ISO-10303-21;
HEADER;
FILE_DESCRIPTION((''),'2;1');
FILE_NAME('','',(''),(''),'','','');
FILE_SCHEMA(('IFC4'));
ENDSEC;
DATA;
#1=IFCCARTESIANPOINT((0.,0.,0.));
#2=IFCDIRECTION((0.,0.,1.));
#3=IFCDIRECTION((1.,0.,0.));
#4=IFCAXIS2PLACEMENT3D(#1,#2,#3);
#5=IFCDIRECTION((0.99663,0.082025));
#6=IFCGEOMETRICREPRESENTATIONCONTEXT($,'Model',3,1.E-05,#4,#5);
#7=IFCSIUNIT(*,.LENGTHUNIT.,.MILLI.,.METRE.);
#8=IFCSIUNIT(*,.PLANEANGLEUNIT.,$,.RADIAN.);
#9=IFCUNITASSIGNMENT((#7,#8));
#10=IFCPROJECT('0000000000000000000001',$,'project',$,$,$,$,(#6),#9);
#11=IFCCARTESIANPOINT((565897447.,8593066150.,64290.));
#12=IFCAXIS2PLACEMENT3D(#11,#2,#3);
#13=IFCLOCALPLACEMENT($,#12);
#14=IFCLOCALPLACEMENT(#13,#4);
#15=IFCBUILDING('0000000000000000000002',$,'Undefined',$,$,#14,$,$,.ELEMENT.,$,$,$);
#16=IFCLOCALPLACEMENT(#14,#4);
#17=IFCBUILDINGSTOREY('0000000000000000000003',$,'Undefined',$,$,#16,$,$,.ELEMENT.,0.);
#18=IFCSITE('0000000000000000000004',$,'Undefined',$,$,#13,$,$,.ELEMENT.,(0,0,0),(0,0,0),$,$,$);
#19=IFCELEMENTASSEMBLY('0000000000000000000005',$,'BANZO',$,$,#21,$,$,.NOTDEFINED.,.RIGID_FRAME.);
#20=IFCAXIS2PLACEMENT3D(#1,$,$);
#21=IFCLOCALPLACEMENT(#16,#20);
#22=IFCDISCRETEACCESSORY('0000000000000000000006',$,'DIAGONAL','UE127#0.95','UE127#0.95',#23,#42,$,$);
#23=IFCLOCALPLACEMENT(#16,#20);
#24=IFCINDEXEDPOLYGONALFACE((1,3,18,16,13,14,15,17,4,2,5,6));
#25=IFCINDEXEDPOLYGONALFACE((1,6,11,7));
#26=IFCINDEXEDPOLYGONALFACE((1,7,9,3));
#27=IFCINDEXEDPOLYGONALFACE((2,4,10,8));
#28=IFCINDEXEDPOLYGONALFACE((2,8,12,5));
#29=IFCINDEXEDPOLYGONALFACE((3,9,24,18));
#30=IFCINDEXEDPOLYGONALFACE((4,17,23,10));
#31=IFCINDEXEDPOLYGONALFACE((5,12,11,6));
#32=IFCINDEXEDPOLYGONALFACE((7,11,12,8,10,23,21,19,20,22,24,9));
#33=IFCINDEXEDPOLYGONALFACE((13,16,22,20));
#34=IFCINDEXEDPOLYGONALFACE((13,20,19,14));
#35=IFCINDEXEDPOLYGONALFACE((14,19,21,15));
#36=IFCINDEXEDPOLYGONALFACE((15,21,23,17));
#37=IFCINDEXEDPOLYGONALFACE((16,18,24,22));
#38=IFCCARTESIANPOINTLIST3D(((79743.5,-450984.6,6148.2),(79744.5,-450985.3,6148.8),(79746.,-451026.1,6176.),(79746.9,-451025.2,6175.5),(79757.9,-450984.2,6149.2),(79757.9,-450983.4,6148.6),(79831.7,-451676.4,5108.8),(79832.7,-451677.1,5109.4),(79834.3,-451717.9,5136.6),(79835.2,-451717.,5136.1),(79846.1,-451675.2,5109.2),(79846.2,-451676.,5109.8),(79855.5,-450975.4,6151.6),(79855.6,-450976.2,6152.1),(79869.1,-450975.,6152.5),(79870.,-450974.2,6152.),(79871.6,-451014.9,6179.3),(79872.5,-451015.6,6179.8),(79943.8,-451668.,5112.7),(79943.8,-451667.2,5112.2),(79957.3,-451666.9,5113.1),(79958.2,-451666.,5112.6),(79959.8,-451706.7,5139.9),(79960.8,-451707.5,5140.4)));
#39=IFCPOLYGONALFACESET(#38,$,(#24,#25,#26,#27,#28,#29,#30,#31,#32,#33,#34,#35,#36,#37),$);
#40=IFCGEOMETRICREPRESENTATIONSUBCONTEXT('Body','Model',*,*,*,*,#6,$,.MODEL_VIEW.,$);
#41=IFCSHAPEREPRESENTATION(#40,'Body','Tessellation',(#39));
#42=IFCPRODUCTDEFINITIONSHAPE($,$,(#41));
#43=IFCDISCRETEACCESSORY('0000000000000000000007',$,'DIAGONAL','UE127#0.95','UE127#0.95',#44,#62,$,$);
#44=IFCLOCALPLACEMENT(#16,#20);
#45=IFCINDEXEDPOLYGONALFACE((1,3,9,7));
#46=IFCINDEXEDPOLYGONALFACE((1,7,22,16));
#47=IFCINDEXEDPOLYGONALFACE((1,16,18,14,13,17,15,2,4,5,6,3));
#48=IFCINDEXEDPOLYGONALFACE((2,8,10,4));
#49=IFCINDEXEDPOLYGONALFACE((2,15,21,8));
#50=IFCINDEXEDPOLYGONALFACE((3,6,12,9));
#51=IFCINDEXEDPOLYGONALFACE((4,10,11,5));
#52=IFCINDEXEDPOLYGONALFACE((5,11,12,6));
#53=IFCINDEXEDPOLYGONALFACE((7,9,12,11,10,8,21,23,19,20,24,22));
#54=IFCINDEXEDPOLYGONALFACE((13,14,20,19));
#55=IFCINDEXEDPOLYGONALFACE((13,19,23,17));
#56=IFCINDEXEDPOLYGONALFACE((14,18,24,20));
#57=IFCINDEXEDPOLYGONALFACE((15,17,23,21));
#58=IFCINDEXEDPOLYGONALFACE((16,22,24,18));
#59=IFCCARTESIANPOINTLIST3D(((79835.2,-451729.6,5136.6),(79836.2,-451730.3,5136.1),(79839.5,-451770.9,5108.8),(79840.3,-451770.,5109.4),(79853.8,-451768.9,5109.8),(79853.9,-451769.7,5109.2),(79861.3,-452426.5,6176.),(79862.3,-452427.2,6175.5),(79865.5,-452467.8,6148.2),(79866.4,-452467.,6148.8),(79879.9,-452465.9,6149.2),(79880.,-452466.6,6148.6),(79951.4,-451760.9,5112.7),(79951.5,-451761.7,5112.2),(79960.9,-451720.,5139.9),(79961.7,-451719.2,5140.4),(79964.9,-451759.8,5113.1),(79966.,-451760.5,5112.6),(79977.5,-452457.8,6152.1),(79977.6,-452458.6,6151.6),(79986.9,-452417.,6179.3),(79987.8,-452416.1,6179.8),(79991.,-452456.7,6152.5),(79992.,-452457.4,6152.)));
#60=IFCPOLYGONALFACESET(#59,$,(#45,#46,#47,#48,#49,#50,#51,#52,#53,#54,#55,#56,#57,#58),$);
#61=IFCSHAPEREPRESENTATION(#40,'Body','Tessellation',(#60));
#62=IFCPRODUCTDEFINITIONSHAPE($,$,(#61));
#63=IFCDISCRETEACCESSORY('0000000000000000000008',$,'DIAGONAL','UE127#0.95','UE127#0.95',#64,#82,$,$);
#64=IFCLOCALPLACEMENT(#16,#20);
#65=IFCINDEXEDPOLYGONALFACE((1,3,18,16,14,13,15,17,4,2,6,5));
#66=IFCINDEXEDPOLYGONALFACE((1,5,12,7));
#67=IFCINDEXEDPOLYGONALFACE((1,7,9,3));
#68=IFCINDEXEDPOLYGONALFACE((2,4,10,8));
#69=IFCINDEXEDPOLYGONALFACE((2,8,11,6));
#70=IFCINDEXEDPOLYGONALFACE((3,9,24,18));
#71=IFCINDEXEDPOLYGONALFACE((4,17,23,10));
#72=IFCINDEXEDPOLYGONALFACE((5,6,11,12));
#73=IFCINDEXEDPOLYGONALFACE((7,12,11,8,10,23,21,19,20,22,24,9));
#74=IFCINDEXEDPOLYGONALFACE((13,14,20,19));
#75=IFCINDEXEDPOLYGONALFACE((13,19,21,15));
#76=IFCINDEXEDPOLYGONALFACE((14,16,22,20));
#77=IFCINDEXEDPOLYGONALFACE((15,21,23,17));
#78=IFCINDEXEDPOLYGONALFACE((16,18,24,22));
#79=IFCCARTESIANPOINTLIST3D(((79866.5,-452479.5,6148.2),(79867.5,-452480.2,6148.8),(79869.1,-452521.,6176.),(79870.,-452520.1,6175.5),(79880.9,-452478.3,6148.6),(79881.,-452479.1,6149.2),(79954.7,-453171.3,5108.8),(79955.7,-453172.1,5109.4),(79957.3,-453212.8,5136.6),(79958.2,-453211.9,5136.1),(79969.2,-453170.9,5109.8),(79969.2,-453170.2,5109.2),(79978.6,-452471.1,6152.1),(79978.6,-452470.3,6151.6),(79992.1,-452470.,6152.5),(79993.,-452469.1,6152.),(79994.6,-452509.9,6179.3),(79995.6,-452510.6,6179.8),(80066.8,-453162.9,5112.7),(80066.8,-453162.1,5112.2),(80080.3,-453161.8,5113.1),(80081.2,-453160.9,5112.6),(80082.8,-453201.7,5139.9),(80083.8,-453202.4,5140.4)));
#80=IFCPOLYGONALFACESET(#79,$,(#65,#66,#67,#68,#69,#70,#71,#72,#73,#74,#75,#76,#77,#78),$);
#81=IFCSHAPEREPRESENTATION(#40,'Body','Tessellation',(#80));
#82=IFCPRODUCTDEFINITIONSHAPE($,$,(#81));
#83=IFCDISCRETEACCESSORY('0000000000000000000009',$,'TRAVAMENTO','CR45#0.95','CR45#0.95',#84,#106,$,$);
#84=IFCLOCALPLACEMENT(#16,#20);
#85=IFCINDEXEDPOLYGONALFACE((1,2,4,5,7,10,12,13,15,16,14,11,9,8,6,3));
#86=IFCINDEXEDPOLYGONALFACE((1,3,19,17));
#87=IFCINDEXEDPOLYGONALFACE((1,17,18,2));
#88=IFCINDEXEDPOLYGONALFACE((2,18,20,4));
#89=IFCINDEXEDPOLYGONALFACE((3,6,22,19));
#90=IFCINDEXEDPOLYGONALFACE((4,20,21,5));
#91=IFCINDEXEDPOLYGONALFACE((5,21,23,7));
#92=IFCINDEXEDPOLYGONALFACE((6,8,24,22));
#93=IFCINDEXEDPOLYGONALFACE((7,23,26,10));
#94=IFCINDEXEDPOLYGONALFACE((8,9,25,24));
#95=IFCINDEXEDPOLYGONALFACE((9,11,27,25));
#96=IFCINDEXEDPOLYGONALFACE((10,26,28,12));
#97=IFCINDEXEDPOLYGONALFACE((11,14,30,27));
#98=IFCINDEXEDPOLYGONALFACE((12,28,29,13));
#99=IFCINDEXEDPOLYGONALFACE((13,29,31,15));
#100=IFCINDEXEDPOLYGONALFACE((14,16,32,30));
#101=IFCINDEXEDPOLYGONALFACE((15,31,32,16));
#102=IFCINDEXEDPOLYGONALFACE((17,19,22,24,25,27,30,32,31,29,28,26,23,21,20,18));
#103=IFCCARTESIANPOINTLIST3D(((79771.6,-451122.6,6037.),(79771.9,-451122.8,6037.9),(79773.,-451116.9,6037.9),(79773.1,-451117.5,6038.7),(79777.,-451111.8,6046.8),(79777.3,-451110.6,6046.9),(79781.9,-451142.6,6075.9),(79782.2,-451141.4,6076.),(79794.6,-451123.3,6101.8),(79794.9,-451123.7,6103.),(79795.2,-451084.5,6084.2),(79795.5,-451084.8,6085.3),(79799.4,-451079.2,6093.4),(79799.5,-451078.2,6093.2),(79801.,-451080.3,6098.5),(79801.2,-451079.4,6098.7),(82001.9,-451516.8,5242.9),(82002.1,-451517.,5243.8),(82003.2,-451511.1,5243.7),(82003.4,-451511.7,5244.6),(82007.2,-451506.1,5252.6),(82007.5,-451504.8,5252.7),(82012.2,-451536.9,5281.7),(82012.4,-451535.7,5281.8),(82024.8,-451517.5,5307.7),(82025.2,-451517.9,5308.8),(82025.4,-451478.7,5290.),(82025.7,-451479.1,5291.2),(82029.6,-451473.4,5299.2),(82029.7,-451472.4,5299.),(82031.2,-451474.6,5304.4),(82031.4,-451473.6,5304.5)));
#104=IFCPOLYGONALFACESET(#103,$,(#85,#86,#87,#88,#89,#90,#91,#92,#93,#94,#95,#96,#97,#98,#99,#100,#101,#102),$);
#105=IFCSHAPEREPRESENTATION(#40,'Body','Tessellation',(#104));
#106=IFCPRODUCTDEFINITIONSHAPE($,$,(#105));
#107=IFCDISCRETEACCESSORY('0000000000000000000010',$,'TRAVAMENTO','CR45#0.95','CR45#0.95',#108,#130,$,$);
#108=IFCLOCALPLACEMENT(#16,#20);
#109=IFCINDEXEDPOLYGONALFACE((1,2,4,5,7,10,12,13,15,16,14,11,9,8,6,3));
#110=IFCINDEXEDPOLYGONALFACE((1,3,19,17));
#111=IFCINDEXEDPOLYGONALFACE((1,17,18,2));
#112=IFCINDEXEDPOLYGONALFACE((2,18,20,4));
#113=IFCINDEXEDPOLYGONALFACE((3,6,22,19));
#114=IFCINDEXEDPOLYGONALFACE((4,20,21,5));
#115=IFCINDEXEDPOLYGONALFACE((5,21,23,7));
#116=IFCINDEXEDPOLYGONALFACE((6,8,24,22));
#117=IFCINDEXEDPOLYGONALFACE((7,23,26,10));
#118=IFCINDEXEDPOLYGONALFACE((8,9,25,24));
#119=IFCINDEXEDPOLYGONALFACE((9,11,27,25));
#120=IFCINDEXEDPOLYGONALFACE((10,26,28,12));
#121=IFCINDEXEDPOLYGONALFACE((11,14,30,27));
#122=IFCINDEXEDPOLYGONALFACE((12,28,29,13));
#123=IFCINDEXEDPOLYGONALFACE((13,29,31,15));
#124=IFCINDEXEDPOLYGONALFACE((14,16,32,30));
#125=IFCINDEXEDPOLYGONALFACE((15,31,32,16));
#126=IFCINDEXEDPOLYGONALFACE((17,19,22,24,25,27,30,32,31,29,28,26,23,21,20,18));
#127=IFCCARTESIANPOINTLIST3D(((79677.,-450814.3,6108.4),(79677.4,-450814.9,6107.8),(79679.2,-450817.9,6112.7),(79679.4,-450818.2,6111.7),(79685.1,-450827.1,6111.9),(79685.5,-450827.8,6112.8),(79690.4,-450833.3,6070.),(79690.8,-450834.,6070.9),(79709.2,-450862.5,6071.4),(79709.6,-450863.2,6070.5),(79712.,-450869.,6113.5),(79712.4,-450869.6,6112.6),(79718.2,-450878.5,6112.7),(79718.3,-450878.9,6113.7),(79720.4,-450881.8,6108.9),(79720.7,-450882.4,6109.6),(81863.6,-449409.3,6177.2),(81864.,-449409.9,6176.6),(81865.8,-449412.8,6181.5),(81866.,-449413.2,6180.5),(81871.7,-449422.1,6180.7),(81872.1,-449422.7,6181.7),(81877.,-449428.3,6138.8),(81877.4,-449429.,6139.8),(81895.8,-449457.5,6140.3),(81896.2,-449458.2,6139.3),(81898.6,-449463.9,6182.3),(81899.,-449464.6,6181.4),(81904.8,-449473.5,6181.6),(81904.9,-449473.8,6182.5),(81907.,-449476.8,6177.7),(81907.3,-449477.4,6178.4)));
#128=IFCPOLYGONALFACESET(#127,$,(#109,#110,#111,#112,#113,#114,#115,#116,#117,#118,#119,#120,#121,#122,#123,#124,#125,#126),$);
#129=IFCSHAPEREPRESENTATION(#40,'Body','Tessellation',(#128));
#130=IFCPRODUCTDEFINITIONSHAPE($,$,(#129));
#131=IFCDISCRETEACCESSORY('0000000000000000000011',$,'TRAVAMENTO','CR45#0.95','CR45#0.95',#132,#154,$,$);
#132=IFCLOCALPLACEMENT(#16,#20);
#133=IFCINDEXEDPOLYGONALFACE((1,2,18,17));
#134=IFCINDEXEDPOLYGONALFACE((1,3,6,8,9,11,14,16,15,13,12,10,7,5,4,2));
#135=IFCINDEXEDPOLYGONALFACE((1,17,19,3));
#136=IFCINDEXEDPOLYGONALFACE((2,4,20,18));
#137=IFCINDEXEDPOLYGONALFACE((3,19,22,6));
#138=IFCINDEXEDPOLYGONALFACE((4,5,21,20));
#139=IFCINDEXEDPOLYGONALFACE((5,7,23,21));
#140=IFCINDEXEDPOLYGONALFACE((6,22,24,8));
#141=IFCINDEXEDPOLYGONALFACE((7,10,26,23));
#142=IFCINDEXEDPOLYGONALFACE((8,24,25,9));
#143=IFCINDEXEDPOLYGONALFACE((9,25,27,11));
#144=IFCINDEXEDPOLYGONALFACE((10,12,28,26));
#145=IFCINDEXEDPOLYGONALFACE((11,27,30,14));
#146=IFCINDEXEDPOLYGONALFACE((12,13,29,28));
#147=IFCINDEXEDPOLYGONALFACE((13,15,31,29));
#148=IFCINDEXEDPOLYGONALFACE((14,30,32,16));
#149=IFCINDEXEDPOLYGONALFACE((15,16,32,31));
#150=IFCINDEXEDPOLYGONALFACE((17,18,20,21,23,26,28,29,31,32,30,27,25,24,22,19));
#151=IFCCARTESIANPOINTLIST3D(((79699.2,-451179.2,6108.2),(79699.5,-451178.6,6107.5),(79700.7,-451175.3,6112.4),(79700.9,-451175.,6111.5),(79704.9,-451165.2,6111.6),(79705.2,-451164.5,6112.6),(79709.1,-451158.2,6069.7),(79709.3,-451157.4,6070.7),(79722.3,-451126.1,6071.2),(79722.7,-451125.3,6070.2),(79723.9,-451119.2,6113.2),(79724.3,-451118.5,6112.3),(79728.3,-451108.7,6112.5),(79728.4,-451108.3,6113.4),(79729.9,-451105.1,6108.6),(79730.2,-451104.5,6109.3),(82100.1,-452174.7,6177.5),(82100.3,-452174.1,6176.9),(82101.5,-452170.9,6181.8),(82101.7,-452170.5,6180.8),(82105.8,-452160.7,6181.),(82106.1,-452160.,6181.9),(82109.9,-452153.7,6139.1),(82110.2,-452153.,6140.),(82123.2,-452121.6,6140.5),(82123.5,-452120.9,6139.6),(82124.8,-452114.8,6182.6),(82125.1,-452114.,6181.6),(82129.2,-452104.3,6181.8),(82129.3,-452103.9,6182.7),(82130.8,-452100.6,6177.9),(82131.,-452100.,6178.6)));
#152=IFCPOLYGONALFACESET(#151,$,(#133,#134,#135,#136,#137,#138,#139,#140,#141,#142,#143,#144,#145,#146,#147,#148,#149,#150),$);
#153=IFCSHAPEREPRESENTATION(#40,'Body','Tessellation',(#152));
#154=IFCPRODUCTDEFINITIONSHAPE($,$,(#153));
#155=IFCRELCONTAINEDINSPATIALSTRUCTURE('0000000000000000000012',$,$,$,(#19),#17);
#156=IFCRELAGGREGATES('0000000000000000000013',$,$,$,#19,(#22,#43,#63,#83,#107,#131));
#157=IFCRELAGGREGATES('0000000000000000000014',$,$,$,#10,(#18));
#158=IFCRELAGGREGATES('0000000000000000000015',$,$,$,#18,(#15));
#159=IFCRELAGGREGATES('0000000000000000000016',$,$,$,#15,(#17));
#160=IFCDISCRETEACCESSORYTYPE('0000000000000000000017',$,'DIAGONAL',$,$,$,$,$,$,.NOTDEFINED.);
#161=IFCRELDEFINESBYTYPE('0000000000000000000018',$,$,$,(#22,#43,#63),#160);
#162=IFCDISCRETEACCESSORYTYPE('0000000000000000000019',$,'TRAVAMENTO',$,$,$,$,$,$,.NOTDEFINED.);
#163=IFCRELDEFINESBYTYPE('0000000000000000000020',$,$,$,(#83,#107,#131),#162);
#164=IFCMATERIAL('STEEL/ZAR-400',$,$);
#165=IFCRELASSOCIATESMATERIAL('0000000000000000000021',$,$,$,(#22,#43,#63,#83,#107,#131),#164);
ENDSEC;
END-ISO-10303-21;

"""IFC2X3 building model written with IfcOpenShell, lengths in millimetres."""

from ifc_helpers import new_model, si_unit, direction, frame, frame_2d, origin_with_axes, place, context, subcontext, project, spatial, polyline, c_section, outline, extrude, material, type_object, element, aggregate, save


model = new_model("IFC2X3")

# Units and contexts
model_context = context("Model", 3, precision=1e-05, world=origin_with_axes(), true_north=direction((0.99663, 0.082025)))
body_context = subcontext(model_context, "Body", "Model", "MODEL_VIEW")
ifc_project = project(units=[si_unit("LENGTHUNIT", "METRE", prefix="MILLI"), si_unit("PLANEANGLEUNIT", "RADIAN")], contexts=[model_context])

# Site, building, storey
site_placement = place(None, frame((565897447.0, 8593066150.0, 64290.0), z_axis=(0.0, 0.0, 1.0), x_axis=(1.0, 0.0, 0.0)))
site = spatial("IfcSite", under=ifc_project, at=site_placement, Name="Undefined", CompositionType="ELEMENT", RefLatitude=(0, 0, 0), RefLongitude=(0, 0, 0))
building_placement = place(site_placement, origin_with_axes())
building = spatial("IfcBuilding", under=site, at=building_placement, Name="Undefined", CompositionType="ELEMENT")
storey_placement = place(building_placement, origin_with_axes())
storey = spatial("IfcBuildingStorey", under=building, at=storey_placement, Name="Undefined", CompositionType="ELEMENT", Elevation=0.0)

# Element assembly, discrete accessories
assembly_1_placement = place(storey_placement, origin_with_axes())
assembly_1 = element("IfcElementAssembly", 1, at=assembly_1_placement, inside=storey, Name="BANZO", AssemblyPlace="NOTDEFINED", PredefinedType="RIGID_FRAME")
ifc_material_1 = material(Name="STEEL/ZAR-400")
discrete_accessory_type_1 = type_object("IfcDiscreteAccessoryType", Name="DIAGONAL")
discrete_accessory_1_placement = place(assembly_1_placement, frame((79808.0, -451000.1, 6164.0), z_axis=(-0.996182, -0.081989, -0.029987), x_axis=(0.070485, -0.552697, -0.830396)))
discrete_accessory_1 = element("IfcDiscreteAccessory", 2, at=discrete_accessory_1_placement, type_object=discrete_accessory_type_1, material=ifc_material_1, Name="DIAGONAL", Description="UE127#0.95", ObjectType="UE127#0.95", context=body_context, shape_type="SweptSolid", body=[
    extrude(c_section(Depth=127.0, Width=50.0, WallThickness=0.9, Girth=14.5, at=frame_2d((0.0, 0.0), x_axis=(1.0, 0.0))), frame((1251.7, 0.0, 0.0), z_axis=(-1.0, 0.0, 0.0), x_axis=(0.0, -1.0, 0.0)), (0.0, 0.0, 1.0), 1251.7),
])
discrete_accessory_2_placement = place(assembly_1_placement, frame((79900.6, -451745.0, 5124.6), z_axis=(-0.996182, -0.081989, -0.029987), x_axis=(0.020829, -0.556784, 0.830396)))
discrete_accessory_2 = element("IfcDiscreteAccessory", 3, at=discrete_accessory_2_placement, type_object=discrete_accessory_type_1, material=ifc_material_1, Name="DIAGONAL", Description="UE127#0.95", ObjectType="UE127#0.95", context=body_context, shape_type="SweptSolid", body=[
    extrude(c_section(Depth=127.0, Width=50.0, WallThickness=0.9, Girth=14.5, at=frame_2d((0.0, 0.0), x_axis=(1.0, 0.0))), frame((1251.7, 0.0, 0.0), z_axis=(-1.0, 0.0, 0.0), x_axis=(0.0, -1.0, 0.0)), (0.0, 0.0, 1.0), 1251.7),
])
discrete_accessory_3_placement = place(assembly_1_placement, frame((79931.0, -452495.1, 6164.0), z_axis=(-0.996182, -0.081989, -0.029987), x_axis=(0.070485, -0.552697, -0.830396)))
discrete_accessory_3 = element("IfcDiscreteAccessory", 4, at=discrete_accessory_3_placement, type_object=discrete_accessory_type_1, material=ifc_material_1, Name="DIAGONAL", Description="UE127#0.95", ObjectType="UE127#0.95", context=body_context, shape_type="SweptSolid", body=[
    extrude(c_section(Depth=127.0, Width=50.0, WallThickness=0.9, Girth=14.5, at=frame_2d((0.0, 0.0), x_axis=(1.0, 0.0))), frame((1251.7, 0.0, 0.0), z_axis=(-1.0, 0.0, 0.0), x_axis=(0.0, -1.0, 0.0)), (0.0, 0.0, 1.0), 1251.7),
])
discrete_accessory_type_2 = type_object("IfcDiscreteAccessoryType", Name="TRAVAMENTO")
discrete_accessory_4_placement = place(assembly_1_placement, frame((82017.4, -451509.8, 5283.1), z_axis=(0.05151, -0.82934, 0.556366), x_axis=(-0.929259, 0.164269, 0.330898)))
discrete_accessory_4 = element("IfcDiscreteAccessory", 5, at=discrete_accessory_4_placement, type_object=discrete_accessory_type_2, material=ifc_material_1, Name="TRAVAMENTO", Description="CR45#0.95", ObjectType="CR45#0.95", context=body_context, shape_type="SweptSolid", body=[
    extrude(outline(polyline([(-35.5, -20.5), (-24.9, -20.5), (-17.4, 21.5), (18.1, 21.5), (25.6, -20.5), (36.2, -20.5), (40.1, -16.6), (40.8, -17.3), (36.6, -21.5), (24.8, -21.5), (17.3, 20.5), (-16.6, 20.5), (-24.1, -21.5), (-35.9, -21.5), (-40.1, -17.3), (-39.4, -16.6), (-35.5, -20.5)])), frame((2400.0, 0.0, 0.0), z_axis=(-1.0, 0.0, 0.0), x_axis=(0.0, -1.0, 0.0)), (0.0, 0.0, 1.0), 2400.0),
])
discrete_accessory_5_placement = place(assembly_1_placement, frame((79699.6, -450848.6, 6091.7), z_axis=(0.029886, 0.00246, -0.99955), x_axis=(0.840995, 0.540395, 0.026476)))
discrete_accessory_5 = element("IfcDiscreteAccessory", 6, at=discrete_accessory_5_placement, type_object=discrete_accessory_type_2, material=ifc_material_1, Name="TRAVAMENTO", Description="CR45#0.95", ObjectType="CR45#0.95", context=body_context, shape_type="SweptSolid", body=[
    extrude(outline(polyline([(-35.5, -20.5), (-24.9, -20.5), (-17.4, 21.5), (18.1, 21.5), (25.6, -20.5), (36.2, -20.5), (40.1, -16.6), (40.8, -17.3), (36.6, -21.5), (24.8, -21.5), (17.3, 20.5), (-16.6, 20.5), (-24.1, -21.5), (-35.9, -21.5), (-40.1, -17.3), (-39.4, -16.6), (-35.5, -20.5)])), frame((2600.0, 0.0, 0.0), z_axis=(-1.0, 0.0, 0.0), x_axis=(0.0, -1.0, 0.0)), (0.0, 0.0, 1.0), 2600.0),
])
discrete_accessory_6_placement = place(assembly_1_placement, frame((82116.2, -452137.0, 6160.8), z_axis=(0.029887, 0.002459, -0.99955), x_axis=(-0.923403, 0.382903, -0.026668)))
discrete_accessory_6 = element("IfcDiscreteAccessory", 7, at=discrete_accessory_6_placement, type_object=discrete_accessory_type_2, material=ifc_material_1, Name="TRAVAMENTO", Description="CR45#0.95", ObjectType="CR45#0.95", context=body_context, shape_type="SweptSolid", body=[
    extrude(outline(polyline([(-35.5, -20.5), (-24.9, -20.5), (-17.4, 21.5), (18.1, 21.5), (25.6, -20.5), (36.2, -20.5), (40.1, -16.6), (40.8, -17.3), (36.6, -21.5), (24.8, -21.5), (17.3, 20.5), (-16.6, 20.5), (-24.1, -21.5), (-35.9, -21.5), (-40.1, -17.3), (-39.4, -16.6), (-35.5, -20.5)])), frame((2600.0, 0.0, 0.0), z_axis=(-1.0, 0.0, 0.0), x_axis=(0.0, -1.0, 0.0)), (0.0, 0.0, 1.0), 2600.0),
])
aggregate(assembly_1, [discrete_accessory_1, discrete_accessory_2, discrete_accessory_3, discrete_accessory_4, discrete_accessory_5, discrete_accessory_6])

save(model, "model.ifc")
